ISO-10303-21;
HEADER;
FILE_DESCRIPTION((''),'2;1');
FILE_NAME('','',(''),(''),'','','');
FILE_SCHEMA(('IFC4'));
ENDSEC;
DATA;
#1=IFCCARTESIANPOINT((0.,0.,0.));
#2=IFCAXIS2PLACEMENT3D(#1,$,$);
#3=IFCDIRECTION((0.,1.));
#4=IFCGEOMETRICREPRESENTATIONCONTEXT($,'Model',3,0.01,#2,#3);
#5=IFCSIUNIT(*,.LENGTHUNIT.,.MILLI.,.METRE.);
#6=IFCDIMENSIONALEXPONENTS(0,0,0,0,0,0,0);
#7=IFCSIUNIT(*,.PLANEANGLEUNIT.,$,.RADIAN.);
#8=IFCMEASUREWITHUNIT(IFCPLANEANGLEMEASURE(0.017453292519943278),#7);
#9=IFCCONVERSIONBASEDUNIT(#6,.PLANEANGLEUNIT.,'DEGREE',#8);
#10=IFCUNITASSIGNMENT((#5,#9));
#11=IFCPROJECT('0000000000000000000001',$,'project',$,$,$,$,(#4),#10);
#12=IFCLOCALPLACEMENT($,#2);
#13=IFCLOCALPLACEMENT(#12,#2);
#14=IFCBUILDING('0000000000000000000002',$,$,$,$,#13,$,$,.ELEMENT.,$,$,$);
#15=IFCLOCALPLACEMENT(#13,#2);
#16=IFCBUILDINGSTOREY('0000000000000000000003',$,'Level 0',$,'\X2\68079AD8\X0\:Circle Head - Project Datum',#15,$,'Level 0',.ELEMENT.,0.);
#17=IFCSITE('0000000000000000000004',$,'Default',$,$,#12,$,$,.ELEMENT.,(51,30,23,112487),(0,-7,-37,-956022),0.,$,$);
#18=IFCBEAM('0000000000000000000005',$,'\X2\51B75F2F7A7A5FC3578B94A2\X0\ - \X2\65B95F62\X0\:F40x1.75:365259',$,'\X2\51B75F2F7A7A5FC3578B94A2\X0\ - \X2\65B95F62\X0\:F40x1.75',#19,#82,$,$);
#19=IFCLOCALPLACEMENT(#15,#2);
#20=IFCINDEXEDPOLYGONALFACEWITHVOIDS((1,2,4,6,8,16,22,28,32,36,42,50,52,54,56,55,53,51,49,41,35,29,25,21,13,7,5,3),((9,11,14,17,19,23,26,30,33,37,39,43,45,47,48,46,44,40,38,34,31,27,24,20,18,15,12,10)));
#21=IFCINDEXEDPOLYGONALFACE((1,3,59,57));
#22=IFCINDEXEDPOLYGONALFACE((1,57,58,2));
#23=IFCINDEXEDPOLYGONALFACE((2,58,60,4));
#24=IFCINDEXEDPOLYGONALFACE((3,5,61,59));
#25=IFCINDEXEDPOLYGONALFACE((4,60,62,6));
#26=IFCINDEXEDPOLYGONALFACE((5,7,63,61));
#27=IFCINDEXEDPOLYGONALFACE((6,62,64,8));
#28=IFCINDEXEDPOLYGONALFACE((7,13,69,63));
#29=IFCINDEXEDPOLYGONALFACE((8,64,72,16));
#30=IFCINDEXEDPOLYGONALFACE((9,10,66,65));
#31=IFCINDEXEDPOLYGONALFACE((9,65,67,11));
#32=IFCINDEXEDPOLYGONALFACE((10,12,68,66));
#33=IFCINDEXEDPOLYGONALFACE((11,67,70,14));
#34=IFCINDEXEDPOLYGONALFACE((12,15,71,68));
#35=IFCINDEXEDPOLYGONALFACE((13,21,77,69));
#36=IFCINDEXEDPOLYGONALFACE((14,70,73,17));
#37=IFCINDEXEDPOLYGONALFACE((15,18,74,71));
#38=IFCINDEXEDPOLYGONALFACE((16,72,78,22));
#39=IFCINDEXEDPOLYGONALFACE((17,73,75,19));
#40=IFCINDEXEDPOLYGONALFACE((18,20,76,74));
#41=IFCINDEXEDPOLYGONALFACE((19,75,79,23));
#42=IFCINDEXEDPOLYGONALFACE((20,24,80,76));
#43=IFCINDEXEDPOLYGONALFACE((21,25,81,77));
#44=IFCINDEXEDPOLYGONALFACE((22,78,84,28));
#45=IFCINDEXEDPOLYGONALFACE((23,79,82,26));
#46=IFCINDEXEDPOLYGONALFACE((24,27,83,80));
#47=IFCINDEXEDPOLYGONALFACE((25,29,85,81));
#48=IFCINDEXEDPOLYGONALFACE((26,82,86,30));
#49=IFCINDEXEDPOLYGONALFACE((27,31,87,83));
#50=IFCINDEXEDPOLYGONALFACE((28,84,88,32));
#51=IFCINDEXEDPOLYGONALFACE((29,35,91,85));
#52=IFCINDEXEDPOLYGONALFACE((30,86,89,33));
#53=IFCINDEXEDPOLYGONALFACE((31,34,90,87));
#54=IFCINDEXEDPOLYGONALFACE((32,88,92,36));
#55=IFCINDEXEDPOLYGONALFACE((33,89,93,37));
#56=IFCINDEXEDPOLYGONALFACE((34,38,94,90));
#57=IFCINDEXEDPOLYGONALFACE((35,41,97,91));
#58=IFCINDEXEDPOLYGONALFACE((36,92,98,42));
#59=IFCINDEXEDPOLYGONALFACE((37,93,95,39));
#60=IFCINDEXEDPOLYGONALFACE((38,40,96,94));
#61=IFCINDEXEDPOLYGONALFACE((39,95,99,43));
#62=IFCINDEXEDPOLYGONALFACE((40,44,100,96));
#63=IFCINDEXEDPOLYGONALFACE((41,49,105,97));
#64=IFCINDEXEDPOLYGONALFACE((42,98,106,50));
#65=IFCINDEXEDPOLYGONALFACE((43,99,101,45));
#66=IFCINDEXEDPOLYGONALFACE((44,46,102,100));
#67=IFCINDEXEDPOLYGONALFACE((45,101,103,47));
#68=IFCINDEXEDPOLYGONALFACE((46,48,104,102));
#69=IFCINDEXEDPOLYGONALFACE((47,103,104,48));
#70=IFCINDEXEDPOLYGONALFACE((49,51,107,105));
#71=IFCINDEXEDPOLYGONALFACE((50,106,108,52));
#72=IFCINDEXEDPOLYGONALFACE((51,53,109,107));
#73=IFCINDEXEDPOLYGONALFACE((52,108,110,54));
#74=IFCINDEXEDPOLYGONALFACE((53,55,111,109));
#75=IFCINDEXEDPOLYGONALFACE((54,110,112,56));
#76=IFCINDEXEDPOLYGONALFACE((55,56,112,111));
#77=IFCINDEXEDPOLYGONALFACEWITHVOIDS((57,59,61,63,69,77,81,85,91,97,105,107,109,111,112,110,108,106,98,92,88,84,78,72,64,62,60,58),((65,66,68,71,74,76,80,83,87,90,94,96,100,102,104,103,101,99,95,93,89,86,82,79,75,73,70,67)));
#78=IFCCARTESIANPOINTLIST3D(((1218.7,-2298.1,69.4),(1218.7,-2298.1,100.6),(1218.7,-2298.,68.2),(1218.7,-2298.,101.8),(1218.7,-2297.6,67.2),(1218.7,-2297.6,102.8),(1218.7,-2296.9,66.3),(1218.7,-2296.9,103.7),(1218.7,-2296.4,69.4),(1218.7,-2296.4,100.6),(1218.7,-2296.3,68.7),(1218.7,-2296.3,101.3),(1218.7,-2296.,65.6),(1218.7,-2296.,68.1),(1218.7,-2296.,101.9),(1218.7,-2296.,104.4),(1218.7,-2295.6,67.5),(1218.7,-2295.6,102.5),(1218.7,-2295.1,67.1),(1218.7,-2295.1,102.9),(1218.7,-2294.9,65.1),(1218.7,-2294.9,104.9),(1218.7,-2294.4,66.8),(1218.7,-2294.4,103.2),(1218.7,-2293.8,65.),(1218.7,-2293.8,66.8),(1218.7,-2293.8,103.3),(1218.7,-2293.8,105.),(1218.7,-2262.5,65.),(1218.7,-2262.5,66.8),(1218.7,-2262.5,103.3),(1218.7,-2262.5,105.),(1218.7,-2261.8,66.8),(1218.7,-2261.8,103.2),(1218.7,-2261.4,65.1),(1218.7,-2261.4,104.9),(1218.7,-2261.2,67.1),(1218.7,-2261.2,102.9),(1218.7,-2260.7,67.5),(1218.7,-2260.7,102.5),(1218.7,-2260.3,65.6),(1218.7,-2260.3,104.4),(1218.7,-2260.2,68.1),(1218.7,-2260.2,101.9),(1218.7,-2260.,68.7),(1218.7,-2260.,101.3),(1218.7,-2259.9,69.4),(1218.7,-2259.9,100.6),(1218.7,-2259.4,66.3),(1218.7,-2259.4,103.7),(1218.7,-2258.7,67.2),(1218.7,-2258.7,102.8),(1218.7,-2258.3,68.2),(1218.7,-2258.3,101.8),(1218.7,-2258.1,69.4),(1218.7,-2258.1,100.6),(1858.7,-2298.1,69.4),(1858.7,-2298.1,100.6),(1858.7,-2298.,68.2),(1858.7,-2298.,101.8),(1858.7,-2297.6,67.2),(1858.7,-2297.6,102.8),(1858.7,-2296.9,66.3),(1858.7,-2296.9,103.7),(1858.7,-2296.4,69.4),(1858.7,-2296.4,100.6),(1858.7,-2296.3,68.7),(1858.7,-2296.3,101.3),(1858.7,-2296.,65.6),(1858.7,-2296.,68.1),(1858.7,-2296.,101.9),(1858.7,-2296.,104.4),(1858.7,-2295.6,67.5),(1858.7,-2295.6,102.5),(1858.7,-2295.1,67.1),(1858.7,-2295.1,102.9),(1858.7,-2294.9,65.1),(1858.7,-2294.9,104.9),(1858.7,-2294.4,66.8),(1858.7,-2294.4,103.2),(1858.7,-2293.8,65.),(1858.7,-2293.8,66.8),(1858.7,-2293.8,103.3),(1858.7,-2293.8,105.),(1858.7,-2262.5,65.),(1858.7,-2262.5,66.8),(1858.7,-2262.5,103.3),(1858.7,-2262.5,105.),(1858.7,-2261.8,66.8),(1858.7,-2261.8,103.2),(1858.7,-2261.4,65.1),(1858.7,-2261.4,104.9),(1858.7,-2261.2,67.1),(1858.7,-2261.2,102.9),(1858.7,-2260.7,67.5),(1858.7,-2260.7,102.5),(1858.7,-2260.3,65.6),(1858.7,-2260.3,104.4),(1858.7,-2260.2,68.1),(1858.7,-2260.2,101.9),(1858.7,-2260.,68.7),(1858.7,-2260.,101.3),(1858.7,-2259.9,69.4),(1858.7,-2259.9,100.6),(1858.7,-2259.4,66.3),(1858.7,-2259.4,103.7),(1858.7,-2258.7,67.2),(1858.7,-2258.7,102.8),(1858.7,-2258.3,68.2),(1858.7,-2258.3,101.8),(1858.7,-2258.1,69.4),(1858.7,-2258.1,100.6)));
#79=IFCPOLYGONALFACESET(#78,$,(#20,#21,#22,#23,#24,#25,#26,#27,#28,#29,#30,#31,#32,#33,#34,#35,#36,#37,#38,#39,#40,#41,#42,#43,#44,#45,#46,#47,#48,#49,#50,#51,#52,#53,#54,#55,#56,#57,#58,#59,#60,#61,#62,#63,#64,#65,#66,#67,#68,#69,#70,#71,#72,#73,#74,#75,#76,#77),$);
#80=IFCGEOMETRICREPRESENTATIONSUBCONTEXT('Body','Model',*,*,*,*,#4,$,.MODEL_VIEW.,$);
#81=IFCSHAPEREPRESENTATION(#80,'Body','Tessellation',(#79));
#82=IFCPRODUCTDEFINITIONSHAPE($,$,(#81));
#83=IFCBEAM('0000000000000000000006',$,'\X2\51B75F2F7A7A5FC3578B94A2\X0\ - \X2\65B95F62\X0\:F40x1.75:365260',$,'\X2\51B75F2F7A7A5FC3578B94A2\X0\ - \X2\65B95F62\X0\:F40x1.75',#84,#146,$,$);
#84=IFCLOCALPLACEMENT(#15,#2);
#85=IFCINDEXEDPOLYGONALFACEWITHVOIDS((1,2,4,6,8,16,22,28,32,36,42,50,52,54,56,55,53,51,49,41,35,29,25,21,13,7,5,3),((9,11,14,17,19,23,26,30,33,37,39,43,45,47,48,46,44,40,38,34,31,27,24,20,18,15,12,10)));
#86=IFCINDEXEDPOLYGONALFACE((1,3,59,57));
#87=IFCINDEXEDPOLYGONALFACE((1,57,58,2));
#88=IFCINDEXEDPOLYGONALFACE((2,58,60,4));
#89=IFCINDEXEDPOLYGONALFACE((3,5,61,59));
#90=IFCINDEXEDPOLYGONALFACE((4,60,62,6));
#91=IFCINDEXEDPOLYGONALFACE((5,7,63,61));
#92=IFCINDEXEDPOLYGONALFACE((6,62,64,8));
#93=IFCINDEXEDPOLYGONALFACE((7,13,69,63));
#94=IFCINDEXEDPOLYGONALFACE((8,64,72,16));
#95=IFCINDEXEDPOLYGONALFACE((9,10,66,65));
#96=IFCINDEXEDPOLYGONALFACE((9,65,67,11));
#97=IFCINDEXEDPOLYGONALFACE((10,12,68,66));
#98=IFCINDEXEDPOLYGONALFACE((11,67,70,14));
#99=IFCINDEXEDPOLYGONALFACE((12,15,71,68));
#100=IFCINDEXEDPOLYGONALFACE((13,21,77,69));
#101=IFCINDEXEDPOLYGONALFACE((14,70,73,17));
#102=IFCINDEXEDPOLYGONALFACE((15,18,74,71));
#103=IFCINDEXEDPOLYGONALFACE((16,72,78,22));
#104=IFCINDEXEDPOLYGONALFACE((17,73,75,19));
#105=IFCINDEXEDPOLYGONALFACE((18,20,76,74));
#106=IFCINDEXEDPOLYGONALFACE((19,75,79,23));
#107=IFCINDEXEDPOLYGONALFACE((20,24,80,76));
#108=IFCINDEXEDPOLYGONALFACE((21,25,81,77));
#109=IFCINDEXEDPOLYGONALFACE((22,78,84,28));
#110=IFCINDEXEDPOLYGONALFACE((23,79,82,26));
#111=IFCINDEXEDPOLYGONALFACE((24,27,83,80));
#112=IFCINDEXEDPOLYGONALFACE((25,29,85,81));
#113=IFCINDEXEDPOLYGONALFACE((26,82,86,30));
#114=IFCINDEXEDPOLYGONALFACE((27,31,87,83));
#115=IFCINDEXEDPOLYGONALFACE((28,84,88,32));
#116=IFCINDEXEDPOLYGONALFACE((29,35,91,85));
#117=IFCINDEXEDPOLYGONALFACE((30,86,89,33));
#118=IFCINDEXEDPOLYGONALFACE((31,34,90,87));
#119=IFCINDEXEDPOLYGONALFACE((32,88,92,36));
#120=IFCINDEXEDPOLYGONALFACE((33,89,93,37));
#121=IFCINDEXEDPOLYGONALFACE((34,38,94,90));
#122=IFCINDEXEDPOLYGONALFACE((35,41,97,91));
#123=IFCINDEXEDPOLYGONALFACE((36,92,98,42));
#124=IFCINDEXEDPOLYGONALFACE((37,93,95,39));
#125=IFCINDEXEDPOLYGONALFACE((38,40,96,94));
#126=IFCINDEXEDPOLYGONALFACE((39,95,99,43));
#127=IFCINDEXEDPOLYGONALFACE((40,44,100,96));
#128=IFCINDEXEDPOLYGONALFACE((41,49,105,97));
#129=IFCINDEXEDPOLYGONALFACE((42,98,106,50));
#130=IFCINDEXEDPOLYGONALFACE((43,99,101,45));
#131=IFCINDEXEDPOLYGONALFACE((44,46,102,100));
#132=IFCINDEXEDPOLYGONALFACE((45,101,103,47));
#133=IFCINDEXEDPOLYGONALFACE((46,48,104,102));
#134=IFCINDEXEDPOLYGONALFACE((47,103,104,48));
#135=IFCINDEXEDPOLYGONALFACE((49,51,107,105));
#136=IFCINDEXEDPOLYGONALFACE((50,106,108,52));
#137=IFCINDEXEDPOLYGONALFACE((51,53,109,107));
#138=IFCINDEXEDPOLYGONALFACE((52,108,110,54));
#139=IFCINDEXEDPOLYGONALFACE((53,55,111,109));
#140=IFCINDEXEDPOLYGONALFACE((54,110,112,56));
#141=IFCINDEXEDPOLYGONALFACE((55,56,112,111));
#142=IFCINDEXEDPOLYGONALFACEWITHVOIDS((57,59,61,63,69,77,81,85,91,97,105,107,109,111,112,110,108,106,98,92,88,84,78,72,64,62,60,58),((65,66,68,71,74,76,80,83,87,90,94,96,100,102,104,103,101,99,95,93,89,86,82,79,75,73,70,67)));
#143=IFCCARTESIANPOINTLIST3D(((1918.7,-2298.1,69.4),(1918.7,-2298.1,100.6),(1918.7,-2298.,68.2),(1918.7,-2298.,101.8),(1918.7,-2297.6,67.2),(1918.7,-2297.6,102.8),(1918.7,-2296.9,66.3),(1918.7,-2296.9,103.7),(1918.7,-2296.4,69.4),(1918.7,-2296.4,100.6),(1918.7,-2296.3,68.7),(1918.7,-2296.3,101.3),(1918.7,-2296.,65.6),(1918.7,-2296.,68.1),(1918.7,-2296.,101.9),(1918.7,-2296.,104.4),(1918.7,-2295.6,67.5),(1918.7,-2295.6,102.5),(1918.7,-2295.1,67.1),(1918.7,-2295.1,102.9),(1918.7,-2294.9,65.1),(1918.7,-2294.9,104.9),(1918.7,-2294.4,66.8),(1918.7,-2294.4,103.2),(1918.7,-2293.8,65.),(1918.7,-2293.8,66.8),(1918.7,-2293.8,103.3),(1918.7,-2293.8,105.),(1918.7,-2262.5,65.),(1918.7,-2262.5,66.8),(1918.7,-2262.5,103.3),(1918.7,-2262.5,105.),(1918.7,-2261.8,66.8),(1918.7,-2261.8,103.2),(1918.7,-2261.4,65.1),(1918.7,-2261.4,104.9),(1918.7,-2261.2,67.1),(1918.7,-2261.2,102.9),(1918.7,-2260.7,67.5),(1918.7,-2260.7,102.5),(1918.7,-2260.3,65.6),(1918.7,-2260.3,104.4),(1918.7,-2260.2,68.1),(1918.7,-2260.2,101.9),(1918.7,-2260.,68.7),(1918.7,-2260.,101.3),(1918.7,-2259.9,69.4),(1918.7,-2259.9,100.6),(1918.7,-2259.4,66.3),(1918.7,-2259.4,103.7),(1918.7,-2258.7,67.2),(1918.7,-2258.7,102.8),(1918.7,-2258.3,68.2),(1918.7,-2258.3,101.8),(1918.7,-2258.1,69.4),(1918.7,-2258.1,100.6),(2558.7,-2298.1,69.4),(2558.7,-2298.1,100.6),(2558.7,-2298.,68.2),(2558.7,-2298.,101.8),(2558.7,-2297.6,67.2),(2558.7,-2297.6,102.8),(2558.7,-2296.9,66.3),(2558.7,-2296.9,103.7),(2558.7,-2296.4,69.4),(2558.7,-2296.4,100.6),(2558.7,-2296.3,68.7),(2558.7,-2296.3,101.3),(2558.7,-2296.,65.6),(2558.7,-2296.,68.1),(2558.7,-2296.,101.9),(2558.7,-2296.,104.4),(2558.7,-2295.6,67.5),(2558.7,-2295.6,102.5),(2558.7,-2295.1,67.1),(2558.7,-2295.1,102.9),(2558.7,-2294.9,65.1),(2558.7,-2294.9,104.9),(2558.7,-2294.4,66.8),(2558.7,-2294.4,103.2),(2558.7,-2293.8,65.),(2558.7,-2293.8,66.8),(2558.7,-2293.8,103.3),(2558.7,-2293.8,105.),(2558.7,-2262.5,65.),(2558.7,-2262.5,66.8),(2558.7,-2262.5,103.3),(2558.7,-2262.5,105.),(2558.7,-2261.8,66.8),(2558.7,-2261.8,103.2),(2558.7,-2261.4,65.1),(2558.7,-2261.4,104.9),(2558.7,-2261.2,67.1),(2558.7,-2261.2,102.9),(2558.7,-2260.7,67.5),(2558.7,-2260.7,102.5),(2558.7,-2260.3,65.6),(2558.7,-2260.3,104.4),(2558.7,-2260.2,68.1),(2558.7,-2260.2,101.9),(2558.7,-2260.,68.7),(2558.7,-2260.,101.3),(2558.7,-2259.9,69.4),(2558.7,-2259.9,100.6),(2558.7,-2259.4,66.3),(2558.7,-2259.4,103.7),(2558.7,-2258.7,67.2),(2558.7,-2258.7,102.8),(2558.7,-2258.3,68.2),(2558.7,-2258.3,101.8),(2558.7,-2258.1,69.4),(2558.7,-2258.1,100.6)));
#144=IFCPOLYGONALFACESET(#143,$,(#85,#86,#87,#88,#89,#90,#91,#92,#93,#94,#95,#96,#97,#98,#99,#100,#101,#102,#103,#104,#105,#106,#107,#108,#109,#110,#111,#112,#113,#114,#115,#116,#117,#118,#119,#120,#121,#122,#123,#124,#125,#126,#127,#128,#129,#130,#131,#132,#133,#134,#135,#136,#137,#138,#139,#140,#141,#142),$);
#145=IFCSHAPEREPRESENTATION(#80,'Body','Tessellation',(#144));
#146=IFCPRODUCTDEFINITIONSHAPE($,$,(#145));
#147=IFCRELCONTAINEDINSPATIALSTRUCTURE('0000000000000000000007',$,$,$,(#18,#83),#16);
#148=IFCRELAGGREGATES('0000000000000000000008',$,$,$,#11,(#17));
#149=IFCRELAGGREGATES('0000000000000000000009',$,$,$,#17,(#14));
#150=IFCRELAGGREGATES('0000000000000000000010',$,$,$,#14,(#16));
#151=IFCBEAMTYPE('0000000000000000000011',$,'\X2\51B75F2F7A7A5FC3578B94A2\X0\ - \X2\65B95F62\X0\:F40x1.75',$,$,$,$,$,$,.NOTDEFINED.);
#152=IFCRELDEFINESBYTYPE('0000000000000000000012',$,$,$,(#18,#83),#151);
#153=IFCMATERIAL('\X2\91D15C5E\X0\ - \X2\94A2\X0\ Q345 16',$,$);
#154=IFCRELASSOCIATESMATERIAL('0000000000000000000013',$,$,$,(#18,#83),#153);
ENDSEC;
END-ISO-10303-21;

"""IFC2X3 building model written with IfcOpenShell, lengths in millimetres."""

from ifc_helpers import new_model, entity, si_unit, converted_unit, direction, frame, frame_2d, origin, place, context, subcontext, project, spatial, polyline, circle_curve, parameter, trimmed, segment, composite_curve, outline, extrude, material, type_object, element, save


model = new_model("IFC2X3")

# Units and contexts
model_context = context("Model", 3, precision=0.01, world=origin(), true_north=direction((0.0, 1.0)))
body_context = subcontext(model_context, "Body", "Model", "MODEL_VIEW")
ifc_project = project(units=[si_unit("LENGTHUNIT", "METRE", prefix="MILLI"), converted_unit("PLANEANGLEUNIT", "DEGREE", entity("IfcPlaneAngleMeasure", 0.017453292519943278), si_unit("PLANEANGLEUNIT", "RADIAN"), dimensions=[0, 0, 0, 0, 0, 0, 0])], contexts=[model_context])

# Site, building, storey
site_placement = place(None, origin())
site = spatial("IfcSite", under=ifc_project, at=site_placement, Name="Default", CompositionType="ELEMENT", RefLatitude=(51, 30, 23, 112487), RefLongitude=(0, -7, -37, -956022), RefElevation=0.0)
building_placement = place(site_placement, origin())
building = spatial("IfcBuilding", under=site, at=building_placement, CompositionType="ELEMENT")
storey_placement = place(building_placement, origin())
storey = spatial("IfcBuildingStorey", under=building, at=storey_placement, Name="Level 0", ObjectType="标高:Circle Head - Project Datum", LongName="Level 0", CompositionType="ELEMENT", Elevation=0.0)

# Beams
ifc_material_1 = material(Name="金属 - 钢 Q345 16")
beam_type_1 = type_object("IfcBeamType", Name="冷弯空心型钢 - 方形:F40x1.75", PredefinedType="NOTDEFINED")
beam_1_placement = place(storey_placement, frame((1723.7, -2278.1, 105.0), z_axis=(0.0, 0.0, 1.0), x_axis=(-1.0, 0.0, 0.0)))
element("IfcBeam", 1, at=beam_1_placement, inside=storey, type_object=beam_type_1, material=ifc_material_1, Name="冷弯空心型钢 - 方形:F40x1.75:365259", ObjectType="冷弯空心型钢 - 方形:F40x1.75", context=body_context, shape_type="SweptSolid", body=[
    extrude(outline(composite_curve([segment(trimmed(circle_curve(frame_2d((-15.6, 15.6), x_axis=(1.0, 0.0)), 4.4), [parameter(90.0)], [parameter(180.0)], True, "PARAMETER"), True, "CONTINUOUS"), segment(polyline([(-20.0, 15.6), (-20.0, -15.6)]), True, "CONTINUOUS"), segment(trimmed(circle_curve(frame_2d((-15.6, -15.6), x_axis=(1.0, 0.0)), 4.4), [parameter(180.0)], [parameter(270.0)], True, "PARAMETER"), True, "CONTINUOUS"), segment(polyline([(-15.6, -20.0), (15.6, -20.0)]), True, "CONTINUOUS"), segment(trimmed(circle_curve(frame_2d((15.6, -15.6), x_axis=(1.0, 0.0)), 4.4), [parameter(270.0)], [parameter(0.0)], True, "PARAMETER"), True, "CONTINUOUS"), segment(polyline([(20.0, -15.6), (20.0, 15.6)]), True, "CONTINUOUS"), segment(trimmed(circle_curve(frame_2d((15.6, 15.6), x_axis=(1.0, 0.0)), 4.4), [parameter(0.0)], [parameter(90.0)], True, "PARAMETER"), True, "CONTINUOUS"), segment(polyline([(15.6, 20.0), (-15.6, 20.0)]), True, "CONTINUOUS")], self_intersect=False), holes=[composite_curve([segment(polyline([(-15.6, 18.3), (15.6, 18.3)]), True, "CONTINUOUS"), segment(trimmed(circle_curve(frame_2d((15.6, 15.6), x_axis=(1.0, 0.0)), 2.6), [parameter(0.0)], [parameter(90.0)], True, "PARAMETER"), False, "CONTINUOUS"), segment(polyline([(18.2, 15.6), (18.2, -15.6)]), True, "CONTINUOUS"), segment(trimmed(circle_curve(frame_2d((15.6, -15.6), x_axis=(1.0, 0.0)), 2.6), [parameter(270.0)], [parameter(360.0)], True, "PARAMETER"), False, "CONTINUOUS"), segment(polyline([(15.6, -18.2), (-15.6, -18.2)]), True, "CONTINUOUS"), segment(trimmed(circle_curve(frame_2d((-15.6, -15.6), x_axis=(1.0, 0.0)), 2.6), [parameter(180.0)], [parameter(270.0)], True, "PARAMETER"), False, "CONTINUOUS"), segment(polyline([(-18.3, -15.6), (-18.3, 15.6)]), True, "CONTINUOUS"), segment(trimmed(circle_curve(frame_2d((-15.6, 15.6), x_axis=(1.0, 0.0)), 2.6), [parameter(90.0)], [parameter(180.0)], True, "PARAMETER"), False, "CONTINUOUS")], self_intersect=False)]), frame((-135.0, 0.0, -20.0), z_axis=(1.0, 0.0, 0.0), x_axis=(0.0, 1.0, 0.0)), (0.0, 0.0, 1.0), 640.0),
])
beam_2_placement = place(storey_placement, frame((2423.7, -2278.1, 105.0), z_axis=(0.0, 0.0, 1.0), x_axis=(-1.0, 0.0, 0.0)))
element("IfcBeam", 2, at=beam_2_placement, inside=storey, type_object=beam_type_1, material=ifc_material_1, Name="冷弯空心型钢 - 方形:F40x1.75:365260", ObjectType="冷弯空心型钢 - 方形:F40x1.75", context=body_context, shape_type="SweptSolid", body=[
    extrude(outline(composite_curve([segment(trimmed(circle_curve(frame_2d((-15.6, 15.6), x_axis=(1.0, 0.0)), 4.4), [parameter(90.0)], [parameter(180.0)], True, "PARAMETER"), True, "CONTINUOUS"), segment(polyline([(-20.0, 15.6), (-20.0, -15.6)]), True, "CONTINUOUS"), segment(trimmed(circle_curve(frame_2d((-15.6, -15.6), x_axis=(1.0, 0.0)), 4.4), [parameter(180.0)], [parameter(270.0)], True, "PARAMETER"), True, "CONTINUOUS"), segment(polyline([(-15.6, -20.0), (15.6, -20.0)]), True, "CONTINUOUS"), segment(trimmed(circle_curve(frame_2d((15.6, -15.6), x_axis=(1.0, 0.0)), 4.4), [parameter(270.0)], [parameter(0.0)], True, "PARAMETER"), True, "CONTINUOUS"), segment(polyline([(20.0, -15.6), (20.0, 15.6)]), True, "CONTINUOUS"), segment(trimmed(circle_curve(frame_2d((15.6, 15.6), x_axis=(1.0, 0.0)), 4.4), [parameter(0.0)], [parameter(90.0)], True, "PARAMETER"), True, "CONTINUOUS"), segment(polyline([(15.6, 20.0), (-15.6, 20.0)]), True, "CONTINUOUS")], self_intersect=False), holes=[composite_curve([segment(polyline([(-15.6, 18.3), (15.6, 18.3)]), True, "CONTINUOUS"), segment(trimmed(circle_curve(frame_2d((15.6, 15.6), x_axis=(1.0, 0.0)), 2.6), [parameter(0.0)], [parameter(90.0)], True, "PARAMETER"), False, "CONTINUOUS"), segment(polyline([(18.2, 15.6), (18.2, -15.6)]), True, "CONTINUOUS"), segment(trimmed(circle_curve(frame_2d((15.6, -15.6), x_axis=(1.0, 0.0)), 2.6), [parameter(270.0)], [parameter(360.0)], True, "PARAMETER"), False, "CONTINUOUS"), segment(polyline([(15.6, -18.2), (-15.6, -18.2)]), True, "CONTINUOUS"), segment(trimmed(circle_curve(frame_2d((-15.6, -15.6), x_axis=(1.0, 0.0)), 2.6), [parameter(180.0)], [parameter(270.0)], True, "PARAMETER"), False, "CONTINUOUS"), segment(polyline([(-18.3, -15.6), (-18.3, 15.6)]), True, "CONTINUOUS"), segment(trimmed(circle_curve(frame_2d((-15.6, 15.6), x_axis=(1.0, 0.0)), 2.6), [parameter(90.0)], [parameter(180.0)], True, "PARAMETER"), False, "CONTINUOUS")], self_intersect=False)]), frame((-135.0, 0.0, -20.0), z_axis=(1.0, 0.0, 0.0), x_axis=(0.0, 1.0, 0.0)), (0.0, 0.0, 1.0), 640.0),
])

save(model, "model.ifc")
